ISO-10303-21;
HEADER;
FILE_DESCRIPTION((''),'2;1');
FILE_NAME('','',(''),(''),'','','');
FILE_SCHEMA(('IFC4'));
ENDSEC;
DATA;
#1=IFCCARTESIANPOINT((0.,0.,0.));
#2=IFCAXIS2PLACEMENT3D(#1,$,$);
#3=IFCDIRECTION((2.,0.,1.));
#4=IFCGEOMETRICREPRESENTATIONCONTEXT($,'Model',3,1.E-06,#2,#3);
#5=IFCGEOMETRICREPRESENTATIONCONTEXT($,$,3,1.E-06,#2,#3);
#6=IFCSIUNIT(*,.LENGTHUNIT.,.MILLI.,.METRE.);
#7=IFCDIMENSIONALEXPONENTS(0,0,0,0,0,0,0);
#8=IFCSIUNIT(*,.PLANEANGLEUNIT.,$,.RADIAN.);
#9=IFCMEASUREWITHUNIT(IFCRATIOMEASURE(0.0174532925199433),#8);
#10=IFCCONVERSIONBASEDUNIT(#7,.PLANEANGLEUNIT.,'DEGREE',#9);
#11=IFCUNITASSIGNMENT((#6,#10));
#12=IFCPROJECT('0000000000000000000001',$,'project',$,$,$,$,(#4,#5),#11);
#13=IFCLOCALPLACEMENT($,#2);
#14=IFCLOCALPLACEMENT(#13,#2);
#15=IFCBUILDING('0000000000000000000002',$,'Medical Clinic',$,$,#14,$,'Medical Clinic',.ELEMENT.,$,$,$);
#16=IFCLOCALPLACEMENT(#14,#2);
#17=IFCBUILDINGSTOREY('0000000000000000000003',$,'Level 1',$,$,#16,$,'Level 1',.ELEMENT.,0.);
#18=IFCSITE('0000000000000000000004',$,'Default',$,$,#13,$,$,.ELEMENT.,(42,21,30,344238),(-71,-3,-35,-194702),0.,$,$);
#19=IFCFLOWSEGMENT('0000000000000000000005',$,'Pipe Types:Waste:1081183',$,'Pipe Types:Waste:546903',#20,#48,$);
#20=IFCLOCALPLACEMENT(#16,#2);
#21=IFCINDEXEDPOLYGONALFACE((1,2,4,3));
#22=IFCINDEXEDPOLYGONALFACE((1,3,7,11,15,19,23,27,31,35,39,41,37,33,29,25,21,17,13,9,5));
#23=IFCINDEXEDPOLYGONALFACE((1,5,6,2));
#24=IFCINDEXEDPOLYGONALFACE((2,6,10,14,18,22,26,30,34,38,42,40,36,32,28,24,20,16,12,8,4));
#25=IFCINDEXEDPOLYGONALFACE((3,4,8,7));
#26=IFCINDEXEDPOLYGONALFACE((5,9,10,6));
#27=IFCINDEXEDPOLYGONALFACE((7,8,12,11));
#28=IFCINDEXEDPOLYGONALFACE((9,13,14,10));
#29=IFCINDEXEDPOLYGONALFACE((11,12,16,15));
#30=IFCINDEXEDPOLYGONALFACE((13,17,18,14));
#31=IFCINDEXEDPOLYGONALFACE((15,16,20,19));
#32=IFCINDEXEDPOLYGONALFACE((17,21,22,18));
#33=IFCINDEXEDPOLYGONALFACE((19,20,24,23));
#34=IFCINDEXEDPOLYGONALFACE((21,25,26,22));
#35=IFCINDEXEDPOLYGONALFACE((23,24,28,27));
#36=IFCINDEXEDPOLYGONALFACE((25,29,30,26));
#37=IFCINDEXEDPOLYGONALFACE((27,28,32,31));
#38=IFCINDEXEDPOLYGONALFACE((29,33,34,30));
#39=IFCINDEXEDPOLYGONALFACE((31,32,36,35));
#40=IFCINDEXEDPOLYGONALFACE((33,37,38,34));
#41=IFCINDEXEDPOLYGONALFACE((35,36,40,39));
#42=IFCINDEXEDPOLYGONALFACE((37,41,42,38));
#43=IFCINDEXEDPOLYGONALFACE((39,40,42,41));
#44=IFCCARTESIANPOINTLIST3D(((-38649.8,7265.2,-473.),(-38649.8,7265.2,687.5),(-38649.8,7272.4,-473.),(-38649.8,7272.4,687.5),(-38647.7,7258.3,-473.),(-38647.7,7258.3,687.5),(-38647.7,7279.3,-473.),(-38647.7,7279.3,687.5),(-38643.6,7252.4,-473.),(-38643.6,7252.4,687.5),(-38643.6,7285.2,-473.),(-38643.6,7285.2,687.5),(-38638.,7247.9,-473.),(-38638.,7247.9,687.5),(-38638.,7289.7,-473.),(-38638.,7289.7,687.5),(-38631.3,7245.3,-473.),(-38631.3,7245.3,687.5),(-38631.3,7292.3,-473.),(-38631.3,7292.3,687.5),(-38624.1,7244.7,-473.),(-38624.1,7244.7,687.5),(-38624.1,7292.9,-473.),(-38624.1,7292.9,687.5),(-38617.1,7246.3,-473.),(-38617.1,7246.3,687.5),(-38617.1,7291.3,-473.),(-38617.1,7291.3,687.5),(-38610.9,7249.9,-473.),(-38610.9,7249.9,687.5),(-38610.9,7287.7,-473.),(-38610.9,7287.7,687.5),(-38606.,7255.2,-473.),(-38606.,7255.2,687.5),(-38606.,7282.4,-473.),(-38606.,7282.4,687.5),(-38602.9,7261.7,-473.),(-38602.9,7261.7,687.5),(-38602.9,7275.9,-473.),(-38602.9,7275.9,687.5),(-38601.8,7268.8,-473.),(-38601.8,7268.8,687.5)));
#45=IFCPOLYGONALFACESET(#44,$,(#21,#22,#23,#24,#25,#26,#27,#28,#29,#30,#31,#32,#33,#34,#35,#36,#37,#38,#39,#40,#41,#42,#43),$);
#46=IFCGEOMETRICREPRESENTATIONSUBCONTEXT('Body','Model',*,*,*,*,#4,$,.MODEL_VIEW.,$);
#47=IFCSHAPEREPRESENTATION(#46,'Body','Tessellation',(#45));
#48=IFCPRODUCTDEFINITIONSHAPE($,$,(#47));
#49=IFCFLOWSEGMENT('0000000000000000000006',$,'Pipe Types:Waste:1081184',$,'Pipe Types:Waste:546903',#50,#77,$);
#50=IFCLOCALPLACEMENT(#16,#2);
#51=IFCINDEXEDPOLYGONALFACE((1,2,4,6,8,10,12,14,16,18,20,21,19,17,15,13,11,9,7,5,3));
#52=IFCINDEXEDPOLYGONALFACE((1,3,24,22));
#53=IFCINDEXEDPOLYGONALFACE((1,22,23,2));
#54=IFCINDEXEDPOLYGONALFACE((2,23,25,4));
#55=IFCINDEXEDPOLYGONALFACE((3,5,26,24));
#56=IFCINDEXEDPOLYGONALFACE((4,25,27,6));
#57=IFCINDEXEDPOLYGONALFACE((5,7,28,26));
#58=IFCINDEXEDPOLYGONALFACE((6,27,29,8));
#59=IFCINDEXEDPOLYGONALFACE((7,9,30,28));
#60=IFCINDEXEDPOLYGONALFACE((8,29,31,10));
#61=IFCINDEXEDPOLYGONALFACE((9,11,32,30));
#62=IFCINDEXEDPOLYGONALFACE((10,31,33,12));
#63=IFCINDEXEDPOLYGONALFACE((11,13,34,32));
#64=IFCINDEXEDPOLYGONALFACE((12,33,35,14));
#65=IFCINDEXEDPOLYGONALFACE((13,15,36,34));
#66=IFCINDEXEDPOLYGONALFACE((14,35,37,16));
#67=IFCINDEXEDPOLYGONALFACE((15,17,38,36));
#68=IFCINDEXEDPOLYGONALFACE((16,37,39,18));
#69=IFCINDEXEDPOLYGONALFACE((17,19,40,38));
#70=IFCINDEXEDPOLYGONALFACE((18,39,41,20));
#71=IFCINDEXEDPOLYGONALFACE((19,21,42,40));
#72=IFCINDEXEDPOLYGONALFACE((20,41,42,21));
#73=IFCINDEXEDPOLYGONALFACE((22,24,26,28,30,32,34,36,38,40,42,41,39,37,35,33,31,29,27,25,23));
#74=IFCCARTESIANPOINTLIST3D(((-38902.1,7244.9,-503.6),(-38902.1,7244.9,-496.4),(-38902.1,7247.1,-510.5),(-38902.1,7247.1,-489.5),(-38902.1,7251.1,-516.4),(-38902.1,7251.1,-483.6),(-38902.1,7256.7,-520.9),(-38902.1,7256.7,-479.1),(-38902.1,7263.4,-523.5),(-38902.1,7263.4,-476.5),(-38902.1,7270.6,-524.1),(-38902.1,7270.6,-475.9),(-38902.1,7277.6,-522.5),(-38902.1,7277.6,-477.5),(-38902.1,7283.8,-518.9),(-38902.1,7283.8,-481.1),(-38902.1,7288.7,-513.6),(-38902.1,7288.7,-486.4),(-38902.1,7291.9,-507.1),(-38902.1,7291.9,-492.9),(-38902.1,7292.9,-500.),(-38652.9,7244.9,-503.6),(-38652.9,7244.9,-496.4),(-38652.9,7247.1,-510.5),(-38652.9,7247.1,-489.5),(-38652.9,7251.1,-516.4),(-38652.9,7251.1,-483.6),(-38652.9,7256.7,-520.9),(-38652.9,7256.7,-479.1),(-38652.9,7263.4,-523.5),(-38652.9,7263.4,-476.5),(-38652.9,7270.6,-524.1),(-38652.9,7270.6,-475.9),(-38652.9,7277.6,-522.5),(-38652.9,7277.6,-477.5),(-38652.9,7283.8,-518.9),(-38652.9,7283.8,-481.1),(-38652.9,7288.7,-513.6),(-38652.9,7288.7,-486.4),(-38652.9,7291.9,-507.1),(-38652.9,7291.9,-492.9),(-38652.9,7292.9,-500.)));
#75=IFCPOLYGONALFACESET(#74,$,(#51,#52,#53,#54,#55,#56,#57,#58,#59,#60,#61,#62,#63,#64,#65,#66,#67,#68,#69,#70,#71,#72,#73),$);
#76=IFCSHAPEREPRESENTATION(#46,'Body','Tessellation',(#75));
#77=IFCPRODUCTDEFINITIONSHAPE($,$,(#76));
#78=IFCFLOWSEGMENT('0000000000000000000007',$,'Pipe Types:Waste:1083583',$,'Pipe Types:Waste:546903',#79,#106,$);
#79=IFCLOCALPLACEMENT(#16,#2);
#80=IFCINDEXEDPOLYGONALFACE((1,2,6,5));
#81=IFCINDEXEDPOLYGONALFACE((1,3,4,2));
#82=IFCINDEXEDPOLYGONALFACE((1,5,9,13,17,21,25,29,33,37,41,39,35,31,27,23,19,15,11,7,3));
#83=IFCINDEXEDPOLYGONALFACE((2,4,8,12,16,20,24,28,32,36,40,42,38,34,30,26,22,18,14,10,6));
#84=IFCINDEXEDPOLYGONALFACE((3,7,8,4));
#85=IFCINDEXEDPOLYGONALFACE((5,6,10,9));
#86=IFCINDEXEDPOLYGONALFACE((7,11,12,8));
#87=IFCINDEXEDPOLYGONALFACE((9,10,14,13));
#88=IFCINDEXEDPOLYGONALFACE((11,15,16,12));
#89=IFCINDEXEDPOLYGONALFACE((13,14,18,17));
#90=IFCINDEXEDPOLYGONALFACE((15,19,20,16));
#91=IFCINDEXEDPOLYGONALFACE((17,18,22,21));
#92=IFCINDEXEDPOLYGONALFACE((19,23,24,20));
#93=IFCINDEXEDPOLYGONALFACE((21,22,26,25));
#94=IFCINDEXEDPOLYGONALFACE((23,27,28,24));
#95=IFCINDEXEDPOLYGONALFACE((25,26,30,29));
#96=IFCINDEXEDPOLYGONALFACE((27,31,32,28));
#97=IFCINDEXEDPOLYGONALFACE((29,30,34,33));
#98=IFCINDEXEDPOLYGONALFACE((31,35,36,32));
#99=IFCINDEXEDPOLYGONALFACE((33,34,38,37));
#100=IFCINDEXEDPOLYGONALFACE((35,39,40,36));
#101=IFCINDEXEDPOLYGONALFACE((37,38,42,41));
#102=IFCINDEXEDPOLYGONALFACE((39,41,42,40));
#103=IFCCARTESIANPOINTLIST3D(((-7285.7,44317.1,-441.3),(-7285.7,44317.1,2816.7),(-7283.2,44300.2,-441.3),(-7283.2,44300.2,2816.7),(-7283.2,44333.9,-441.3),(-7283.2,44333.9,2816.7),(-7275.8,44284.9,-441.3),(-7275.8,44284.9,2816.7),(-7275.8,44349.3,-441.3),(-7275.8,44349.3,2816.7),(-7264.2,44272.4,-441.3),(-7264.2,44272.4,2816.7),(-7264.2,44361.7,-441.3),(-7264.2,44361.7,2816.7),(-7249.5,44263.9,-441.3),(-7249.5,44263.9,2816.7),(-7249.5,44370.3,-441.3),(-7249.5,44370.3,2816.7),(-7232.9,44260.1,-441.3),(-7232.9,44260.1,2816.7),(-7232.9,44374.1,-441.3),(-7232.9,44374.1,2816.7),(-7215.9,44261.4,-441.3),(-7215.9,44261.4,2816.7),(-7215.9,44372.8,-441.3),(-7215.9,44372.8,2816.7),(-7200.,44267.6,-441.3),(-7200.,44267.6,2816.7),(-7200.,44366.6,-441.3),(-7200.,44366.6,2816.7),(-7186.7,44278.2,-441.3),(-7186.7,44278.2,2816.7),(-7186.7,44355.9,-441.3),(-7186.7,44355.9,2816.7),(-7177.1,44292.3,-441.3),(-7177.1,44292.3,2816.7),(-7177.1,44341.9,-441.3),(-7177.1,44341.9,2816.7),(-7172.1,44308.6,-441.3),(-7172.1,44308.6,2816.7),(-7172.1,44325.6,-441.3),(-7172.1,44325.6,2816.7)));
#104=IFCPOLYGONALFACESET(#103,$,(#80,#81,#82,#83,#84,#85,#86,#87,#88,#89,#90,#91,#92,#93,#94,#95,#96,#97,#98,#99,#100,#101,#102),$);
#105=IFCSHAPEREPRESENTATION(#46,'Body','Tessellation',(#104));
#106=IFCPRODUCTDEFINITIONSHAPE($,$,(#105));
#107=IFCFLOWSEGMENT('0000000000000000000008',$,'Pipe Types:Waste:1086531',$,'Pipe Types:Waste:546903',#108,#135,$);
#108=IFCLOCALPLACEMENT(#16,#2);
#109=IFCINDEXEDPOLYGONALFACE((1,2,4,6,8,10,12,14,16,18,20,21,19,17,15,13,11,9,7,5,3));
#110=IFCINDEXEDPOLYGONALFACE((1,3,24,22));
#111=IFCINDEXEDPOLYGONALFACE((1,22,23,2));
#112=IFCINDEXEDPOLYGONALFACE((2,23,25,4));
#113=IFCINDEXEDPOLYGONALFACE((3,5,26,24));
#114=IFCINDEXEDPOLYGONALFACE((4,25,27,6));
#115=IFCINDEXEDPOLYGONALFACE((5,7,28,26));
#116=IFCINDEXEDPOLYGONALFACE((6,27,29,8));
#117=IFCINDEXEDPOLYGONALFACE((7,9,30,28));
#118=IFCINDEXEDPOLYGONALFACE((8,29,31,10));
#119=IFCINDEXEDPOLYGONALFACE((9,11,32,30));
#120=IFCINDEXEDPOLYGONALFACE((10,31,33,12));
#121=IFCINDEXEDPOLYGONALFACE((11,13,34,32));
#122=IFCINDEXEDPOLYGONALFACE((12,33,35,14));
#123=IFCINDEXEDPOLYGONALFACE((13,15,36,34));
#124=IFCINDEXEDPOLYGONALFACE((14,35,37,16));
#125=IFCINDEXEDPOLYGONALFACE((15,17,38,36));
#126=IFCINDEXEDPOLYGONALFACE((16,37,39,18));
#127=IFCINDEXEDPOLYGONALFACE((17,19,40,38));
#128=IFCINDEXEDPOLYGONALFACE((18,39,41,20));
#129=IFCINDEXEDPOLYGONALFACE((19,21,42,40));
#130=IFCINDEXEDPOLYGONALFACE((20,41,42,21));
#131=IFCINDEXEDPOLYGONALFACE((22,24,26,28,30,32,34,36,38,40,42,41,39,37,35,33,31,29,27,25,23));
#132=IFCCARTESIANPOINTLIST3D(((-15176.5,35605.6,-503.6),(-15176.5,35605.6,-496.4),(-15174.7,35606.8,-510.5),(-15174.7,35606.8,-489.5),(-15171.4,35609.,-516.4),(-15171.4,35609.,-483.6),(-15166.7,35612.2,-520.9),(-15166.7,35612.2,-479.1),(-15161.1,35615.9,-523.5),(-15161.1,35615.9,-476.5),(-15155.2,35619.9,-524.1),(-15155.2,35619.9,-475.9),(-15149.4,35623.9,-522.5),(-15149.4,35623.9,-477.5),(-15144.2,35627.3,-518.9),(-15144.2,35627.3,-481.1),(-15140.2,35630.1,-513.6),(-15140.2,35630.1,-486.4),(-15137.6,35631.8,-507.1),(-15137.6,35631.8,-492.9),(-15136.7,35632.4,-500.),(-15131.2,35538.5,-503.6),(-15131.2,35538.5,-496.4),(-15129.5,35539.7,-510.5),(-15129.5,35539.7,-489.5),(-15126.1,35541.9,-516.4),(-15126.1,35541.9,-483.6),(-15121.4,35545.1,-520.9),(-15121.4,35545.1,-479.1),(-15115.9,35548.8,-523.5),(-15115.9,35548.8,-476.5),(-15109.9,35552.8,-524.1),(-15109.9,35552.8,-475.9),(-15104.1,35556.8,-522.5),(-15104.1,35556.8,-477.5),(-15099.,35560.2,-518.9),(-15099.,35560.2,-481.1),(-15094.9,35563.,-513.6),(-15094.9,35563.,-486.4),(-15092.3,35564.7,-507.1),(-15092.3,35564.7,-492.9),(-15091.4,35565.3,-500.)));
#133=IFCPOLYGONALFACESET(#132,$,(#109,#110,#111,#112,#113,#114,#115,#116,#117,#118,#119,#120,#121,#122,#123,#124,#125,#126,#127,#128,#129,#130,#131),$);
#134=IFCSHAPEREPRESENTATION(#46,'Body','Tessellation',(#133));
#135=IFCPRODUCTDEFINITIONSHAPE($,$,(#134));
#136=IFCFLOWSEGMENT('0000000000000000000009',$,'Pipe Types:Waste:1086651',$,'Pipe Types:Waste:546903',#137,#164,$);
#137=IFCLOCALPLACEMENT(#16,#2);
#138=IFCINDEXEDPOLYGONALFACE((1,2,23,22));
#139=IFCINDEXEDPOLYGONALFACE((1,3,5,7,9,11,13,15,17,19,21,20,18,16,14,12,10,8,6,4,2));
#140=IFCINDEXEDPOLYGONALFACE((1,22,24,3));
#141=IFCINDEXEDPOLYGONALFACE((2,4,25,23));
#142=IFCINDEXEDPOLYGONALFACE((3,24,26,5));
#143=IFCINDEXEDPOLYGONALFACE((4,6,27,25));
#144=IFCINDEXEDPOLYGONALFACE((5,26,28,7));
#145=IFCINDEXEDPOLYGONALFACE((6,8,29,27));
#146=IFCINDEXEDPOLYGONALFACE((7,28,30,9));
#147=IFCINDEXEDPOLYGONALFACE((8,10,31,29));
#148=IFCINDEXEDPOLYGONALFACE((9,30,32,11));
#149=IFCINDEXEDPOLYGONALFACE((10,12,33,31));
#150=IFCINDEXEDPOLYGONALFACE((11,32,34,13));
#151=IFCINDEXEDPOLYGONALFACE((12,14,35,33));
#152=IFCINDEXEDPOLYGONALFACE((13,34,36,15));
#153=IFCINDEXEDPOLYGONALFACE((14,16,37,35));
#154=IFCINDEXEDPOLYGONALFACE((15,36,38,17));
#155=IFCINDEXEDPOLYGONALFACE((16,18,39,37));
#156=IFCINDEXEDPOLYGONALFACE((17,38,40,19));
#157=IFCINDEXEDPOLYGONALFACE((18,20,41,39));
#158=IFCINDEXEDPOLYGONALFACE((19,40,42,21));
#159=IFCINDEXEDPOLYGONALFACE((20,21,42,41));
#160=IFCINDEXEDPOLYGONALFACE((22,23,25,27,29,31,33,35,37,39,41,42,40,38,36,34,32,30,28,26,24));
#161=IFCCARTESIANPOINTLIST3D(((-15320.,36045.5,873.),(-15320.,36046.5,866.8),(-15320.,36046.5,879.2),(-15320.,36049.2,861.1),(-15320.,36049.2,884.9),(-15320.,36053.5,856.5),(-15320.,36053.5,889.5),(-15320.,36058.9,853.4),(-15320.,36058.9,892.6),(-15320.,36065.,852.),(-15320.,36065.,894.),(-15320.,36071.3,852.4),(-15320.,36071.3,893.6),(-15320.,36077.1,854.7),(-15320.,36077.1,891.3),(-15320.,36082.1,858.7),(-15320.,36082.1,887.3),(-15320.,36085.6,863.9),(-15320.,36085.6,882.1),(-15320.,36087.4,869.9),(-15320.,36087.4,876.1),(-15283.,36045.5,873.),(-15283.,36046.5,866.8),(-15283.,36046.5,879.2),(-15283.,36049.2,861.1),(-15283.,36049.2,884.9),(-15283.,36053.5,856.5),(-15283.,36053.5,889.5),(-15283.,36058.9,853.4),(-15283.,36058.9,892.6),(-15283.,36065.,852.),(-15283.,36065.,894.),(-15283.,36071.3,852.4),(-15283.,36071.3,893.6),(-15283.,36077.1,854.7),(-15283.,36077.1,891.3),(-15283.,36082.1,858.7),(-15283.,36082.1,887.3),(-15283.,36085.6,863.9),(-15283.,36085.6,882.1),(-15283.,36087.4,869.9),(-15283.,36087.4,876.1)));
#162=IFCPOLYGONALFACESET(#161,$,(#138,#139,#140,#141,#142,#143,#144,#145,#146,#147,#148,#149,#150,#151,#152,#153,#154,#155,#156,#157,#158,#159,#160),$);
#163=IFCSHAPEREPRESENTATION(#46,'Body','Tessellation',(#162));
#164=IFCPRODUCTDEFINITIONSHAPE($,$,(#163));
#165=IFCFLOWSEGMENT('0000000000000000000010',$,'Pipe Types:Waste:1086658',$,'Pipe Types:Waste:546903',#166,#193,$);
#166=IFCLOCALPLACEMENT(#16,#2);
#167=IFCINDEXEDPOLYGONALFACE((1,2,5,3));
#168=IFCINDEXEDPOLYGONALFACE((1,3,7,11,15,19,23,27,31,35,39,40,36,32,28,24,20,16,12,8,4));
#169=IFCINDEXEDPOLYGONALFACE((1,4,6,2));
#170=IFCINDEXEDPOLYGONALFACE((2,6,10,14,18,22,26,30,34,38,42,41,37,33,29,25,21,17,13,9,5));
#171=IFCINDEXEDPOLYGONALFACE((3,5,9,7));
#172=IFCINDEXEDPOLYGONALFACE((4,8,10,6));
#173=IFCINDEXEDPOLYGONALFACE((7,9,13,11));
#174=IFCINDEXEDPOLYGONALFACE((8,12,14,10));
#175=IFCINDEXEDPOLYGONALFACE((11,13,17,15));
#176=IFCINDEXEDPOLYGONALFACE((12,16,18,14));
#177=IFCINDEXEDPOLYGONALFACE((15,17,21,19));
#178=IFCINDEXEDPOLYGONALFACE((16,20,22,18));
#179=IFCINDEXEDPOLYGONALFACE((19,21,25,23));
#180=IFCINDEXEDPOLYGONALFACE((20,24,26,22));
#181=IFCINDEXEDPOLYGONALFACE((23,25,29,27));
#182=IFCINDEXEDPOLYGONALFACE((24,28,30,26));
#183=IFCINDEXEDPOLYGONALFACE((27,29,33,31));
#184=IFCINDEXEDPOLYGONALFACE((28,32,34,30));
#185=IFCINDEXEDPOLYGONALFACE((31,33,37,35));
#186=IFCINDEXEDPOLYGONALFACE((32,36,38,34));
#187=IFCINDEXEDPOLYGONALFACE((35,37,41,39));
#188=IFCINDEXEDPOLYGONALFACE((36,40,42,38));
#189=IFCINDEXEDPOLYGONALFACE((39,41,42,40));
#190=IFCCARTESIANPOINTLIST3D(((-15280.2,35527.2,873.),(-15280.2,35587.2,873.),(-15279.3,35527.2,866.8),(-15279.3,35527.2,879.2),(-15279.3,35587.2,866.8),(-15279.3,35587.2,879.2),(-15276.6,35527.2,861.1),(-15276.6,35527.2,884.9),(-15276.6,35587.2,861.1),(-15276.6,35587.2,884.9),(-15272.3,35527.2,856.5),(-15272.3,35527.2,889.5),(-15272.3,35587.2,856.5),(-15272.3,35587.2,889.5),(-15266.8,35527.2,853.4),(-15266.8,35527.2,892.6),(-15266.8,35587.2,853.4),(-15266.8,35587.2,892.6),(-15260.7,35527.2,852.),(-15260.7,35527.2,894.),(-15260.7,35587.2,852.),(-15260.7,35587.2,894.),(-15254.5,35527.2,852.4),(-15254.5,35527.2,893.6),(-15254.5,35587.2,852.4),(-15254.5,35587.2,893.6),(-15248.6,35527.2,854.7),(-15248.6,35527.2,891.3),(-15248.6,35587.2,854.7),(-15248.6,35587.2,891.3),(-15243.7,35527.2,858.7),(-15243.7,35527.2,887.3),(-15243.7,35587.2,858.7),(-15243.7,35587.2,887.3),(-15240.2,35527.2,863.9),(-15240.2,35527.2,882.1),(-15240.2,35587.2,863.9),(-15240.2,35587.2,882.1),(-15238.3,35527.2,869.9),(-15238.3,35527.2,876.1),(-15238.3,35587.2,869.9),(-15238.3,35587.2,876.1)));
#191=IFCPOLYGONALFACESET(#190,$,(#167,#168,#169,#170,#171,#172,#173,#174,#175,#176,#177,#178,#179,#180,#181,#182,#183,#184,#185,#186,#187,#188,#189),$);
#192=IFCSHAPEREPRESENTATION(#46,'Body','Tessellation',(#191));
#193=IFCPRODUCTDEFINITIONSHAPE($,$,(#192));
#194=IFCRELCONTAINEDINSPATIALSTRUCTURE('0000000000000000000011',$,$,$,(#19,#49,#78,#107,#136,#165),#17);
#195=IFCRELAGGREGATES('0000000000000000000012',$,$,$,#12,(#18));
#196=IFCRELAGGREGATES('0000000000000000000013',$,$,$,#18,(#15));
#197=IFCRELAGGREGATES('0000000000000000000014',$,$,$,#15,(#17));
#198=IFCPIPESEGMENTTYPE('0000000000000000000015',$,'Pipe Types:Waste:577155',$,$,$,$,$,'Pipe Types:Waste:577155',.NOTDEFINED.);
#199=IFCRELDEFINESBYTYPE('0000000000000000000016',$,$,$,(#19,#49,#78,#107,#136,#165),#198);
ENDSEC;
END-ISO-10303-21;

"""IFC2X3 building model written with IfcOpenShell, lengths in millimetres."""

from ifc_helpers import new_model, entity, si_unit, converted_unit, direction, frame, frame_2d, origin, origin_2d_with_axis, place, context, subcontext, project, spatial, circle, extrude, type_object, element, save


model = new_model("IFC2X3")

# Units and contexts
model_context = context("Model", 3, precision=1e-06, world=origin(), true_north=direction((2.0, 0.0, 1.0)))
context_of_model = context(None, 3, precision=1e-06, world=origin(), true_north=direction((2.0, 0.0, 1.0)))
body_context = subcontext(model_context, "Body", "Model", "MODEL_VIEW")
ifc_project = project(units=[si_unit("LENGTHUNIT", "METRE", prefix="MILLI"), converted_unit("PLANEANGLEUNIT", "DEGREE", entity("IfcRatioMeasure", 0.0174532925199433), si_unit("PLANEANGLEUNIT", "RADIAN"), dimensions=[0, 0, 0, 0, 0, 0, 0])], contexts=[model_context, context_of_model])

# Site, building, storey
site_placement = place(None, origin())
site = spatial("IfcSite", under=ifc_project, at=site_placement, Name="Default", CompositionType="ELEMENT", RefLatitude=(42, 21, 30, 344238), RefLongitude=(-71, -3, -35, -194702), RefElevation=0.0)
building_placement = place(site_placement, origin())
building = spatial("IfcBuilding", under=site, at=building_placement, Name="Medical Clinic", LongName="Medical Clinic", CompositionType="ELEMENT")
storey_placement = place(building_placement, origin())
storey = spatial("IfcBuildingStorey", under=building, at=storey_placement, Name="Level 1", LongName="Level 1", CompositionType="ELEMENT", Elevation=0.0)

# Flow segments
pipe_segment_type_1 = type_object("IfcPipeSegmentType", Name="Pipe Types:Waste:577155", ElementType="Pipe Types:Waste:577155", PredefinedType="NOTDEFINED")
flow_segment_1_placement = place(storey_placement, origin())
element("IfcFlowSegment", 1, at=flow_segment_1_placement, inside=storey, type_object=pipe_segment_type_1, Name="Pipe Types:Waste:1081183", ObjectType="Pipe Types:Waste:546903", context=body_context, shape_type="SweptSolid", body=[
    extrude(circle(Radius=24.1, at=origin_2d_with_axis()), frame((-38625.9, 7268.8, -473.0)), (0.0, 0.0, 1.0), 1160.5),
])
flow_segment_2_placement = place(storey_placement, origin())
element("IfcFlowSegment", 2, at=flow_segment_2_placement, inside=storey, type_object=pipe_segment_type_1, Name="Pipe Types:Waste:1081184", ObjectType="Pipe Types:Waste:546903", context=body_context, shape_type="SweptSolid", body=[
    extrude(circle(Radius=24.1, at=origin_2d_with_axis()), frame((-38902.1, 7268.8, -500.0), z_axis=(1.0, 0.0, 0.0), x_axis=(0.0, 1.0, 0.0)), (0.0, 0.0, 1.0), 249.2),
])
flow_segment_3_placement = place(storey_placement, origin())
element("IfcFlowSegment", 3, at=flow_segment_3_placement, inside=storey, type_object=pipe_segment_type_1, Name="Pipe Types:Waste:1083583", ObjectType="Pipe Types:Waste:546903", context=body_context, shape_type="SweptSolid", body=[
    extrude(circle(Radius=57.1, at=origin_2d_with_axis()), frame((-7228.6, 44317.1, -441.3), z_axis=(0.0, 0.0, 1.0), x_axis=(-1.0, 0.0, 0.0)), (0.0, 0.0, 1.0), 3258.0),
])
flow_segment_4_placement = place(storey_placement, origin())
element("IfcFlowSegment", 4, at=flow_segment_4_placement, inside=storey, type_object=pipe_segment_type_1, Name="Pipe Types:Waste:1086531", ObjectType="Pipe Types:Waste:546903", context=body_context, shape_type="SweptSolid", body=[
    extrude(circle(Radius=24.1, at=origin_2d_with_axis()), frame((-15111.4, 35551.8, -500.0), z_axis=(-0.559193, 0.829038, 0.0), x_axis=(0.829038, 0.559193, 0.0)), (0.0, 0.0, 1.0), 80.9),
])
flow_segment_5_placement = place(storey_placement, origin())
element("IfcFlowSegment", 5, at=flow_segment_5_placement, inside=storey, type_object=pipe_segment_type_1, Name="Pipe Types:Waste:1086651", ObjectType="Pipe Types:Waste:546903", context=body_context, shape_type="SweptSolid", body=[
    extrude(circle(Radius=21.1, at=origin_2d_with_axis()), frame((-15320.0, 36066.6, 873.0), z_axis=(1.0, 0.0, 0.0), x_axis=(0.0, -1.0, 0.0)), (0.0, 0.0, 1.0), 37.0),
])
flow_segment_6_placement = place(storey_placement, origin())
element("IfcFlowSegment", 6, at=flow_segment_6_placement, inside=storey, type_object=pipe_segment_type_1, Name="Pipe Types:Waste:1086658", ObjectType="Pipe Types:Waste:546903", context=body_context, shape_type="SweptSolid", body=[
    extrude(circle(Radius=21.1, at=frame_2d((0.0, 0.0), x_axis=(1.0, 0.0))), frame((-15259.1, 35527.2, 873.0), z_axis=(0.0, 1.0, 0.0), x_axis=(-1.0, 0.0, 0.0)), (0.0, 0.0, 1.0), 60.0),
])

save(model, "model.ifc")
